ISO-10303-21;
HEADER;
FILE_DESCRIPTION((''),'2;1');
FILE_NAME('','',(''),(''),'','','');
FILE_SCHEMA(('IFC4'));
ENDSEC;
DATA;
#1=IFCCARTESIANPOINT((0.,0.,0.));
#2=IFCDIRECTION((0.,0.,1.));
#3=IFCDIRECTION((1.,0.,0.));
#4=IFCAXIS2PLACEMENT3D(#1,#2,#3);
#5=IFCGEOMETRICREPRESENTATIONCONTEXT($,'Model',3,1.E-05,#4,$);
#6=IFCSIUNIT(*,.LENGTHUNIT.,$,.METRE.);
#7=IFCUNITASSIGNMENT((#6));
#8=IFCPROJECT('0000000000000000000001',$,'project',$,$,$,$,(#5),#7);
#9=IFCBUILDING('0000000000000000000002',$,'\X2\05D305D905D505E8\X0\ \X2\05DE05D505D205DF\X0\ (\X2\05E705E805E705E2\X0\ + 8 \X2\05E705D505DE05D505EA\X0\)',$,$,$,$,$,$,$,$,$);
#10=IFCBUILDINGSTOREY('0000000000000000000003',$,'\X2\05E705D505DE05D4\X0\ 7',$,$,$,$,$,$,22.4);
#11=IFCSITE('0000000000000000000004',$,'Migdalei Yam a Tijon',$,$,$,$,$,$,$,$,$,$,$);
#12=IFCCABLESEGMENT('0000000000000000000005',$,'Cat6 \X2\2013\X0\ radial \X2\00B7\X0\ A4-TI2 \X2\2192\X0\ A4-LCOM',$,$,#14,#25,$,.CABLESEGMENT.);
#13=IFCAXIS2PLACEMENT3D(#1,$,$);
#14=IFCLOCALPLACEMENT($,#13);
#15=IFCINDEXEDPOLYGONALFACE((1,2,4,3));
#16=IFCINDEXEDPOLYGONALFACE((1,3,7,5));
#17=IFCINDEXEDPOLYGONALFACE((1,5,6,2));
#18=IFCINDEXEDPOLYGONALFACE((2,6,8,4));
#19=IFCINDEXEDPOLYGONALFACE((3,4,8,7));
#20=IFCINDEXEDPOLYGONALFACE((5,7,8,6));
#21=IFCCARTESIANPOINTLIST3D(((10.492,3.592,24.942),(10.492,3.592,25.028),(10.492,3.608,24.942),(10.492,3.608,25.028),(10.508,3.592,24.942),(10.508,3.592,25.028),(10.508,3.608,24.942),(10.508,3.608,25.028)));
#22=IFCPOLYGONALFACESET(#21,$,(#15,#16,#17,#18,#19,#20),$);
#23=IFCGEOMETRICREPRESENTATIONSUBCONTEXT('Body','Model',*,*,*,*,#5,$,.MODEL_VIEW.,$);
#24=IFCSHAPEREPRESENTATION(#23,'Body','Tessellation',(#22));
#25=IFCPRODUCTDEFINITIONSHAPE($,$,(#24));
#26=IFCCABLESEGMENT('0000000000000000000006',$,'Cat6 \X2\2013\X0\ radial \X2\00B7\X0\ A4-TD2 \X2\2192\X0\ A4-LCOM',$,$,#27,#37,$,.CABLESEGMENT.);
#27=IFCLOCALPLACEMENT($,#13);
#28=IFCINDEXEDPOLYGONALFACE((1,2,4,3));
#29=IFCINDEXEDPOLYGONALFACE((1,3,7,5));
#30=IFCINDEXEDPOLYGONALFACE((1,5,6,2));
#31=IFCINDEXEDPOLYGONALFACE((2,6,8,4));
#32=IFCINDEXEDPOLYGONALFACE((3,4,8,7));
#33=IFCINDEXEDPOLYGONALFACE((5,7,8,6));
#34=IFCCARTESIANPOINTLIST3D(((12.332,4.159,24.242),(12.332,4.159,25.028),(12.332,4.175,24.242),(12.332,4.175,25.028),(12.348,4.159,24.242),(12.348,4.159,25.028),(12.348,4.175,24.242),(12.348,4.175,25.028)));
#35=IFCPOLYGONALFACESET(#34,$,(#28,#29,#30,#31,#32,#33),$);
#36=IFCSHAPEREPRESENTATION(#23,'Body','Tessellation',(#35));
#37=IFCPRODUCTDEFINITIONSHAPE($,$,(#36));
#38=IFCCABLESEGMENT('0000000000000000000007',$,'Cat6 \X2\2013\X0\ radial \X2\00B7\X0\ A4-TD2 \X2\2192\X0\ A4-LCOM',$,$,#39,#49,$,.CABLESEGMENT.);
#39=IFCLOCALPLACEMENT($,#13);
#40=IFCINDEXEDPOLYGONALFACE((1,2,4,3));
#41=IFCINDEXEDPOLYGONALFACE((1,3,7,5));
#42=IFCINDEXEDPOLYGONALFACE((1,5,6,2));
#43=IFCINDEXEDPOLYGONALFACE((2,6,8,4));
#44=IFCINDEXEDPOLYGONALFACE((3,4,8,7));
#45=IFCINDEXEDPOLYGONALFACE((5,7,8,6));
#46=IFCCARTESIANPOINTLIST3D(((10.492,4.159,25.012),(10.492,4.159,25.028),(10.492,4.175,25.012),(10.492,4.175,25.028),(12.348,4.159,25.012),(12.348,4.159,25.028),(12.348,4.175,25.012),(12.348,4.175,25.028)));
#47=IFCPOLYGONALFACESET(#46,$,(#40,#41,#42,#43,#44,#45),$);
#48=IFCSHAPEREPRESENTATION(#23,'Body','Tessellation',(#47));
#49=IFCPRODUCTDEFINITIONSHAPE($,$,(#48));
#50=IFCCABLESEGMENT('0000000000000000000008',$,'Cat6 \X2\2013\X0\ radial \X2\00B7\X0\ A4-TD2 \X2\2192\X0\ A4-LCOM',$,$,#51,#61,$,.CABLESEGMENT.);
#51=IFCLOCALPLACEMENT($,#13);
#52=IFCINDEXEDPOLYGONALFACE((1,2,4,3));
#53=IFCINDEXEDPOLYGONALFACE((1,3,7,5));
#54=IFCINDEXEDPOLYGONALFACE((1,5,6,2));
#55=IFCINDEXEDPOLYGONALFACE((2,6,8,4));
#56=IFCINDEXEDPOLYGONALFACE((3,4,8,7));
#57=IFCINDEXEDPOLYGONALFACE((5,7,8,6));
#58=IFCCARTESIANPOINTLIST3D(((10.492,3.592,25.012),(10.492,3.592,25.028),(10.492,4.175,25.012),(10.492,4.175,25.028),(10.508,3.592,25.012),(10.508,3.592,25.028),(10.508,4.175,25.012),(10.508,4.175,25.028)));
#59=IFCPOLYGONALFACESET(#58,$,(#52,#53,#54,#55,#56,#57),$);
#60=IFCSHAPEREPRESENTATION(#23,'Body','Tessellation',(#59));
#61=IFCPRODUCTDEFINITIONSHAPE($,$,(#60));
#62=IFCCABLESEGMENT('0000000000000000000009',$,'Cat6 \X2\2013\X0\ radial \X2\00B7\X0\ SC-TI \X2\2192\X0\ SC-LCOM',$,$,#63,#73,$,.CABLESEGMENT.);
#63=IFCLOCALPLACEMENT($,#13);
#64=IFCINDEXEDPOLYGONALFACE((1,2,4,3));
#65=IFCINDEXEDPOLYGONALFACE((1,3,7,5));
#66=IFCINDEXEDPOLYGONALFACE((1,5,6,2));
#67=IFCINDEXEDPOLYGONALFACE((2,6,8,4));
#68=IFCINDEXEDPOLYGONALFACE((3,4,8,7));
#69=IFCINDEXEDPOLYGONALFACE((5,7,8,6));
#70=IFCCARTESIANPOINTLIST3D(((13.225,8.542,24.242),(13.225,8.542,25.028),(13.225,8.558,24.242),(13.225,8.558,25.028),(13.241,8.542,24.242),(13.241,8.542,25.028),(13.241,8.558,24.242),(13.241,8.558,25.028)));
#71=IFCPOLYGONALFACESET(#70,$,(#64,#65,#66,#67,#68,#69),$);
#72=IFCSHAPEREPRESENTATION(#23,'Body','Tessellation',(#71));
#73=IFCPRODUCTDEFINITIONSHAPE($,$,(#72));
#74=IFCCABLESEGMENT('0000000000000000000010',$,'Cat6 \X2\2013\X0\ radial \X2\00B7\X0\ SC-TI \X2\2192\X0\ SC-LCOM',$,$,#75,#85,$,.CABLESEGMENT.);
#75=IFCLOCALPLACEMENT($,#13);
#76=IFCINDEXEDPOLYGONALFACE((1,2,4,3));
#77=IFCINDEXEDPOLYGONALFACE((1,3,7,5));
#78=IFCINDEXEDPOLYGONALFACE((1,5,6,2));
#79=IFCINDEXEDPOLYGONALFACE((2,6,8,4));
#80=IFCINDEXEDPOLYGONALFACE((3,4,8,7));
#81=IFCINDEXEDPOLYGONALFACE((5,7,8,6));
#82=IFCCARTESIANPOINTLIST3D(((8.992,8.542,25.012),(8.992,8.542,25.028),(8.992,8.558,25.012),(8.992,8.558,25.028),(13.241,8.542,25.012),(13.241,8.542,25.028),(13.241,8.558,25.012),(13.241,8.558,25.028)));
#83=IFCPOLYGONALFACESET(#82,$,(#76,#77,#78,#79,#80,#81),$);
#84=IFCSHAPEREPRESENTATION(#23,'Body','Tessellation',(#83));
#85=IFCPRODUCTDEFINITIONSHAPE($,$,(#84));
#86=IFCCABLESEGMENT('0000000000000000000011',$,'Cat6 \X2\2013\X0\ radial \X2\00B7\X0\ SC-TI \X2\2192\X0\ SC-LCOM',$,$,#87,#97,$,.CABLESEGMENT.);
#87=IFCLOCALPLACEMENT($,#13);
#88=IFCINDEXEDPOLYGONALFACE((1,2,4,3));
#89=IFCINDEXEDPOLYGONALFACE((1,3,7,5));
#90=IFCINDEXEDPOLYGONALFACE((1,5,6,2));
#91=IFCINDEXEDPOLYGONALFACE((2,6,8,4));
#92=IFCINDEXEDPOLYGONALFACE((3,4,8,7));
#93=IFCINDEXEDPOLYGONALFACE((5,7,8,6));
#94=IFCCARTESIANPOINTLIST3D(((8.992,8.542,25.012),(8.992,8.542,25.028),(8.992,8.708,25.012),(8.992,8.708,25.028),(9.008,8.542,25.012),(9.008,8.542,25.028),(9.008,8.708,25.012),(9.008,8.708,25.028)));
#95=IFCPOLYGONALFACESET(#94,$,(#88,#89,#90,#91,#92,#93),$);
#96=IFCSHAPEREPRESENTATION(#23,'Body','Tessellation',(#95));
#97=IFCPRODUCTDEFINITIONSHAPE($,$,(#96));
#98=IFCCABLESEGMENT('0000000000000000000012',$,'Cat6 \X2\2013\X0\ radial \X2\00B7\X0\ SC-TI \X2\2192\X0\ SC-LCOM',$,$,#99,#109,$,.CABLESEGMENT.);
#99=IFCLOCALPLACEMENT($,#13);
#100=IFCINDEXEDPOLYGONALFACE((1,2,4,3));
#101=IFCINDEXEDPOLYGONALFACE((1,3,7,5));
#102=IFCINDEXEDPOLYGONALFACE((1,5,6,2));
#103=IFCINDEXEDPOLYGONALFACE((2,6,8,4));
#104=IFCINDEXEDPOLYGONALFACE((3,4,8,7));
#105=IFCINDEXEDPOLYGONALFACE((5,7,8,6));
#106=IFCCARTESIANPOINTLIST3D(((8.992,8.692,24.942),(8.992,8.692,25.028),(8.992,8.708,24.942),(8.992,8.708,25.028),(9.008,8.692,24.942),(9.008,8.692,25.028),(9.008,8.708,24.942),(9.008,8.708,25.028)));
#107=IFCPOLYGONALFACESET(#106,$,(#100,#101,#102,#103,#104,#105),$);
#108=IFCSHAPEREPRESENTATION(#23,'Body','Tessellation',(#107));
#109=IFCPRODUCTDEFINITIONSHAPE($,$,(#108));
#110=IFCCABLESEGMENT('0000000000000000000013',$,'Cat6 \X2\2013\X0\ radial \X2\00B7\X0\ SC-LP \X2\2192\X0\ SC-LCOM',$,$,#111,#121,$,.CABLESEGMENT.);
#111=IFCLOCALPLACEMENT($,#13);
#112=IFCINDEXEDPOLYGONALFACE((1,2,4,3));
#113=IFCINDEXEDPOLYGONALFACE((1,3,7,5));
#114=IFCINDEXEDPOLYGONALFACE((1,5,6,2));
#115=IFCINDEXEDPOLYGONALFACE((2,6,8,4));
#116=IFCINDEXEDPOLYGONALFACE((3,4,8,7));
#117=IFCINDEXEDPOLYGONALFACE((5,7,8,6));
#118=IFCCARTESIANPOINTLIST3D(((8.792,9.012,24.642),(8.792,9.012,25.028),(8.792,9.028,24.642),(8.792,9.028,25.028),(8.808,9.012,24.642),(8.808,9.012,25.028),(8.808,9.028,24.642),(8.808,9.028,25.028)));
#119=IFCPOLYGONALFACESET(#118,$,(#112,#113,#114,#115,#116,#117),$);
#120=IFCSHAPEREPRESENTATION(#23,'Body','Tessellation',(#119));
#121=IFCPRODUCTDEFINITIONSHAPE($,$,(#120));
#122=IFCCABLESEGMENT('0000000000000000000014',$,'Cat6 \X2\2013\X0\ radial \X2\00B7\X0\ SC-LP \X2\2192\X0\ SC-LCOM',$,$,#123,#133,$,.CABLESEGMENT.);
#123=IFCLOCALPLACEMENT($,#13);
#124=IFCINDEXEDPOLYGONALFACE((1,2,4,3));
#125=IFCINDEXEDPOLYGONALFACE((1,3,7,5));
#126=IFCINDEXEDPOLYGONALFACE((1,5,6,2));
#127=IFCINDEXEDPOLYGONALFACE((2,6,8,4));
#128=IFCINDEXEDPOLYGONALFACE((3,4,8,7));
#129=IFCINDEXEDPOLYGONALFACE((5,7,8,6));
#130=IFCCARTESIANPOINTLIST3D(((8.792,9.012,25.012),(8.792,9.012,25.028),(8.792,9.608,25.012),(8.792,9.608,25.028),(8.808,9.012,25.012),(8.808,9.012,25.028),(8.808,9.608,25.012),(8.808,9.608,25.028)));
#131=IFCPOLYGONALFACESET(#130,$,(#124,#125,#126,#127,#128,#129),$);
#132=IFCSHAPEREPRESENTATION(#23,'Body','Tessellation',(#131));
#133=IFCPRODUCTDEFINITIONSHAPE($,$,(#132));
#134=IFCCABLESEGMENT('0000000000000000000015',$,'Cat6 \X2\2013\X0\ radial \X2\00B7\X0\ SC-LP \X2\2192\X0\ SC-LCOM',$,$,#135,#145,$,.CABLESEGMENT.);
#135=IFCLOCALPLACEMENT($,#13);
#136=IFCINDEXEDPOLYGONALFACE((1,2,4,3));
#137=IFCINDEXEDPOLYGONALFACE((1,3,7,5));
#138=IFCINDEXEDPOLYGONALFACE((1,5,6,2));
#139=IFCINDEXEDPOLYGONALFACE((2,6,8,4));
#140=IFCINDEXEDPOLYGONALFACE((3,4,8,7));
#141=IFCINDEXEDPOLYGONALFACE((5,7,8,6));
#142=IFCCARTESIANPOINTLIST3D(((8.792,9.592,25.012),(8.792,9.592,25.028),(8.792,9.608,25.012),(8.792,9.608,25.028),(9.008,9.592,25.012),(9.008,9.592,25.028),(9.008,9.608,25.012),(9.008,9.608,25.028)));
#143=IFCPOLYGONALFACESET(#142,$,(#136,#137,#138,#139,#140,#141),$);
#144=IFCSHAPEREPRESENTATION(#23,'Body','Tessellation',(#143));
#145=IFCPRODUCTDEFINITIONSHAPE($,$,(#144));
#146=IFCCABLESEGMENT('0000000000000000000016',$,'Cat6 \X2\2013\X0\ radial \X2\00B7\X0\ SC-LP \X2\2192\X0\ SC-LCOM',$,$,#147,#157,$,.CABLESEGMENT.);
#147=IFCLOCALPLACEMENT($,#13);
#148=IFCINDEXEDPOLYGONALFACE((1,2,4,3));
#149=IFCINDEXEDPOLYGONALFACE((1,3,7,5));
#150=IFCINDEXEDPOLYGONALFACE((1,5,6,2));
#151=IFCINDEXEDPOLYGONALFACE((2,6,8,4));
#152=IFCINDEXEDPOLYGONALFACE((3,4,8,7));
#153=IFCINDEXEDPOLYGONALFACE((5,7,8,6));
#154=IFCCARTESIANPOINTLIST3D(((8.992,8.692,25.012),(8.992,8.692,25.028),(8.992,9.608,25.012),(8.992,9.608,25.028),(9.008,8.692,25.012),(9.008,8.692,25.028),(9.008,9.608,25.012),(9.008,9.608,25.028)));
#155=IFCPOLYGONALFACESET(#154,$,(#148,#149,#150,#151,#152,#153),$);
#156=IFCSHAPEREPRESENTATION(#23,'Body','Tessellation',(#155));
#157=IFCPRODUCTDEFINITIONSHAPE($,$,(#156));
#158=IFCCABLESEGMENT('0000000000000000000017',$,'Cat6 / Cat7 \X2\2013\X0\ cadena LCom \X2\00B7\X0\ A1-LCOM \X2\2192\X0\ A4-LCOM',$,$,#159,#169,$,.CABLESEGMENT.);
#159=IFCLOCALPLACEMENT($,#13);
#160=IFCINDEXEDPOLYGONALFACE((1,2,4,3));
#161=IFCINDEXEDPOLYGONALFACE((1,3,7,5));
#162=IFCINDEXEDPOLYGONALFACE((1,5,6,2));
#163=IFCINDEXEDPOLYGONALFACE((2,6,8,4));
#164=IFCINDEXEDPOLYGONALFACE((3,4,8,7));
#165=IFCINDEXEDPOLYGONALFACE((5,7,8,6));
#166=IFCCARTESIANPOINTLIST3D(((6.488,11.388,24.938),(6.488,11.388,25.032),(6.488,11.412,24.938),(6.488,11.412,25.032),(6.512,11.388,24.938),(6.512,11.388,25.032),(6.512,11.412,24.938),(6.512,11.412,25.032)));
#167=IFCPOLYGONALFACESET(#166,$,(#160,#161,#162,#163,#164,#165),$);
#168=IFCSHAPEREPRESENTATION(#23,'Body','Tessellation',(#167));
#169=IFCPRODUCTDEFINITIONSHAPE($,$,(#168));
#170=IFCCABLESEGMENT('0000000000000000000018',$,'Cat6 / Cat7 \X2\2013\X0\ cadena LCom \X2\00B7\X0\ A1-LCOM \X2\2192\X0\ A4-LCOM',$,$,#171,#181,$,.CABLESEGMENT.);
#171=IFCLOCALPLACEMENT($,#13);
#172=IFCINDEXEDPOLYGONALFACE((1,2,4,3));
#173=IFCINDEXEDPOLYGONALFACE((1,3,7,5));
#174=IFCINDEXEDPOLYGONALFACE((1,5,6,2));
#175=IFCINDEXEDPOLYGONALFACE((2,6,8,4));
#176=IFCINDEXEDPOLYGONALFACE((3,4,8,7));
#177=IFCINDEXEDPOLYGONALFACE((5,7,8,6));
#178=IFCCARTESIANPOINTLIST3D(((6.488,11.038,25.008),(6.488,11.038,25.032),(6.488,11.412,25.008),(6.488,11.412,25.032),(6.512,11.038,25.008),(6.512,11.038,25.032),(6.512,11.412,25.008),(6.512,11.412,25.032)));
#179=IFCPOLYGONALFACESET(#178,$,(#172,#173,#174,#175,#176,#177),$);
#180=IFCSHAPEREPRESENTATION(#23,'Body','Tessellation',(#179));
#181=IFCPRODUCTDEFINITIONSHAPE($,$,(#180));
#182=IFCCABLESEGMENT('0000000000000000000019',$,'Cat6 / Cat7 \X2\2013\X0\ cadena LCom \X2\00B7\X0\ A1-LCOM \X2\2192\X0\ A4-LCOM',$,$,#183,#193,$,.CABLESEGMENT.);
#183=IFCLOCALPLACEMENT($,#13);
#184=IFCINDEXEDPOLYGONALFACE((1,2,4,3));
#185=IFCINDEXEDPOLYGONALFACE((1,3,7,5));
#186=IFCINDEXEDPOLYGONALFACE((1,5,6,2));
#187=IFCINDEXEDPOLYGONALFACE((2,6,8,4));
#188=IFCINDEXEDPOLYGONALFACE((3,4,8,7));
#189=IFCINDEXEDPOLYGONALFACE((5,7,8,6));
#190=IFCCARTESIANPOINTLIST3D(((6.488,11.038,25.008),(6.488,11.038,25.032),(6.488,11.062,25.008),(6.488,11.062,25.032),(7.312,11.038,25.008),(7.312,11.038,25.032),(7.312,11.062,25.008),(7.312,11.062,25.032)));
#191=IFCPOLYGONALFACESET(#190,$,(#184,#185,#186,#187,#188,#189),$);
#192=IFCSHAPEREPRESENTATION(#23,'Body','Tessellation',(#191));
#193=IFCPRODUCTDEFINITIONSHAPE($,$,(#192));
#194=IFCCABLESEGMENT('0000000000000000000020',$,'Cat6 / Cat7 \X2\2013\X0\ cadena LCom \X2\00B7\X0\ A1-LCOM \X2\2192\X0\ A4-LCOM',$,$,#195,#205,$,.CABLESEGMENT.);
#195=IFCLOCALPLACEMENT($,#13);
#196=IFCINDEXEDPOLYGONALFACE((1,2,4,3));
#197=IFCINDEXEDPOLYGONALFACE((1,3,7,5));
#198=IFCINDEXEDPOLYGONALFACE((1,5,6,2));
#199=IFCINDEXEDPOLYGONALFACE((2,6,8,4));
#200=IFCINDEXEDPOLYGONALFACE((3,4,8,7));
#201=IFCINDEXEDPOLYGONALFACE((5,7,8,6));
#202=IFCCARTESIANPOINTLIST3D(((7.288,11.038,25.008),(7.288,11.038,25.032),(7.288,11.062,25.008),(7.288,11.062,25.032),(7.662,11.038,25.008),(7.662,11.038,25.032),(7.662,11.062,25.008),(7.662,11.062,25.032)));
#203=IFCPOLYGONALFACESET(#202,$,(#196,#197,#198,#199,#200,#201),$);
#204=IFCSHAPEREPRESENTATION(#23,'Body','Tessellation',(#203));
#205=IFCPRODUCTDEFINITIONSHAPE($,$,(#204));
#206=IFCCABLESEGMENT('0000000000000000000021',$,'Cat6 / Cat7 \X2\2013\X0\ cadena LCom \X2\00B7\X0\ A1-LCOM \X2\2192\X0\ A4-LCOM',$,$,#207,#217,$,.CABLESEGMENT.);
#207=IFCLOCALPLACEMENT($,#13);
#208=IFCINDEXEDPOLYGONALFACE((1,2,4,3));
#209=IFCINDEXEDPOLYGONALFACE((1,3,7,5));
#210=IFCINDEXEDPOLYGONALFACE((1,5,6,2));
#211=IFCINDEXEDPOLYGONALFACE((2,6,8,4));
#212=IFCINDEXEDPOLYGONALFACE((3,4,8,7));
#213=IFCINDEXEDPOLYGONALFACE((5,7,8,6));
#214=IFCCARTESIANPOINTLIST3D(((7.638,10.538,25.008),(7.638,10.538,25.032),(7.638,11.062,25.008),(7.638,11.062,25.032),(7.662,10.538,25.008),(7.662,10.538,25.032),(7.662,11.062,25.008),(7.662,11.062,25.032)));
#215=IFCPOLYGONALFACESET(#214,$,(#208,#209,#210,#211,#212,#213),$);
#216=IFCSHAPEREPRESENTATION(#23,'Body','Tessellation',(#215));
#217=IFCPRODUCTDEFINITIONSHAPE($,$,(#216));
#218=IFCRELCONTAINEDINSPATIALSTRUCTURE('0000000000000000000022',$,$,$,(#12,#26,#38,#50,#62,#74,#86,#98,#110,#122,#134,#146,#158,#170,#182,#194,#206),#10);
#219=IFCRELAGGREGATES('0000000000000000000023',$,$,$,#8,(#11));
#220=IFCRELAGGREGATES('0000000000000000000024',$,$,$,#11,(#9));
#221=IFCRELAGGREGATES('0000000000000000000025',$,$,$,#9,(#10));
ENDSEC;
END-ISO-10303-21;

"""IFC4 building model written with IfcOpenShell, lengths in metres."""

from ifc_helpers import new_model, si_unit, frame, origin_with_axes, context, subcontext, project, spatial, line, indexed_curve, outline, extrude, element, save


model = new_model("IFC4")

# Units and contexts
model_context = context("Model", 3, precision=1e-05, world=origin_with_axes())
body_context = subcontext(model_context, "Body", "Model", "MODEL_VIEW")
ifc_project = project(units=[si_unit("LENGTHUNIT", "METRE")], contexts=[model_context])

# Site, building, storey
site = spatial("IfcSite", under=ifc_project, Name="Migdalei Yam a Tijon")
building = spatial("IfcBuilding", under=site, Name="דיור מוגן (קרקע + 8 קומות)")
storey = spatial("IfcBuildingStorey", under=building, Name="קומה 7", Elevation=22.4)

# Cable segments
element("IfcCableSegment", 1, inside=storey, Name="Cat6 – radial · A4-TI2 → A4-LCOM", PredefinedType="CABLESEGMENT", context=body_context, shape_type="SweptSolid", body=[
    extrude(outline(indexed_curve([(0.0, 0.0), (0.016, 0.0), (0.016, 0.016), (0.0, 0.016)], segments=[line(1, 2, 3, 4, 1)])), frame((10.492, 3.592, 24.942), z_axis=(0.0, 0.0, 1.0), x_axis=(1.0, 0.0, 0.0)), (0.0, 0.0, 1.0), 0.086),
])
element("IfcCableSegment", 2, inside=storey, Name="Cat6 – radial · A4-TD2 → A4-LCOM", PredefinedType="CABLESEGMENT", context=body_context, shape_type="SweptSolid", body=[
    extrude(outline(indexed_curve([(0.0, 0.0), (0.016, 0.0), (0.016, 0.016), (0.0, 0.016)], segments=[line(1, 2, 3, 4, 1)])), frame((12.332, 4.159, 24.242), z_axis=(0.0, 0.0, 1.0), x_axis=(1.0, 0.0, 0.0)), (0.0, 0.0, 1.0), 0.786),
])
element("IfcCableSegment", 3, inside=storey, Name="Cat6 – radial · A4-TD2 → A4-LCOM", PredefinedType="CABLESEGMENT", context=body_context, shape_type="SweptSolid", body=[
    extrude(outline(indexed_curve([(0.0, 0.0), (1.856, 0.0), (1.856, 0.016), (0.0, 0.016)], segments=[line(1, 2, 3, 4, 1)])), frame((10.492, 4.159, 25.012), z_axis=(0.0, 0.0, 1.0), x_axis=(1.0, 0.0, 0.0)), (0.0, 0.0, 1.0), 0.016),
])
element("IfcCableSegment", 4, inside=storey, Name="Cat6 – radial · A4-TD2 → A4-LCOM", PredefinedType="CABLESEGMENT", context=body_context, shape_type="SweptSolid", body=[
    extrude(outline(indexed_curve([(0.0, 0.0), (0.016, 0.0), (0.016, 0.583), (0.0, 0.583)], segments=[line(1, 2, 3, 4, 1)])), frame((10.492, 3.592, 25.012), z_axis=(0.0, 0.0, 1.0), x_axis=(1.0, 0.0, 0.0)), (0.0, 0.0, 1.0), 0.016),
])
element("IfcCableSegment", 5, inside=storey, Name="Cat6 – radial · SC-TI → SC-LCOM", PredefinedType="CABLESEGMENT", context=body_context, shape_type="SweptSolid", body=[
    extrude(outline(indexed_curve([(0.0, 0.0), (0.016, 0.0), (0.016, 0.016), (0.0, 0.016)], segments=[line(1, 2, 3, 4, 1)])), frame((13.225, 8.542, 24.242), z_axis=(0.0, 0.0, 1.0), x_axis=(1.0, 0.0, 0.0)), (0.0, 0.0, 1.0), 0.786),
])
element("IfcCableSegment", 6, inside=storey, Name="Cat6 – radial · SC-TI → SC-LCOM", PredefinedType="CABLESEGMENT", context=body_context, shape_type="SweptSolid", body=[
    extrude(outline(indexed_curve([(0.0, 0.0), (4.249, 0.0), (4.249, 0.016), (0.0, 0.016)], segments=[line(1, 2, 3, 4, 1)])), frame((8.992, 8.542, 25.012), z_axis=(0.0, 0.0, 1.0), x_axis=(1.0, 0.0, 0.0)), (0.0, 0.0, 1.0), 0.016),
])
element("IfcCableSegment", 7, inside=storey, Name="Cat6 – radial · SC-TI → SC-LCOM", PredefinedType="CABLESEGMENT", context=body_context, shape_type="SweptSolid", body=[
    extrude(outline(indexed_curve([(0.0, 0.0), (0.016, 0.0), (0.016, 0.166), (0.0, 0.166)], segments=[line(1, 2, 3, 4, 1)])), frame((8.992, 8.542, 25.012), z_axis=(0.0, 0.0, 1.0), x_axis=(1.0, 0.0, 0.0)), (0.0, 0.0, 1.0), 0.016),
])
element("IfcCableSegment", 8, inside=storey, Name="Cat6 – radial · SC-TI → SC-LCOM", PredefinedType="CABLESEGMENT", context=body_context, shape_type="SweptSolid", body=[
    extrude(outline(indexed_curve([(0.0, 0.0), (0.016, 0.0), (0.016, 0.016), (0.0, 0.016)], segments=[line(1, 2, 3, 4, 1)])), frame((8.992, 8.692, 24.942), z_axis=(0.0, 0.0, 1.0), x_axis=(1.0, 0.0, 0.0)), (0.0, 0.0, 1.0), 0.086),
])
element("IfcCableSegment", 9, inside=storey, Name="Cat6 – radial · SC-LP → SC-LCOM", PredefinedType="CABLESEGMENT", context=body_context, shape_type="SweptSolid", body=[
    extrude(outline(indexed_curve([(0.0, 0.0), (0.016, 0.0), (0.016, 0.016), (0.0, 0.016)], segments=[line(1, 2, 3, 4, 1)])), frame((8.792, 9.012, 24.642), z_axis=(0.0, 0.0, 1.0), x_axis=(1.0, 0.0, 0.0)), (0.0, 0.0, 1.0), 0.386),
])
element("IfcCableSegment", 10, inside=storey, Name="Cat6 – radial · SC-LP → SC-LCOM", PredefinedType="CABLESEGMENT", context=body_context, shape_type="SweptSolid", body=[
    extrude(outline(indexed_curve([(0.0, 0.0), (0.016, 0.0), (0.016, 0.596), (0.0, 0.596)], segments=[line(1, 2, 3, 4, 1)])), frame((8.792, 9.012, 25.012), z_axis=(0.0, 0.0, 1.0), x_axis=(1.0, 0.0, 0.0)), (0.0, 0.0, 1.0), 0.016),
])
element("IfcCableSegment", 11, inside=storey, Name="Cat6 – radial · SC-LP → SC-LCOM", PredefinedType="CABLESEGMENT", context=body_context, shape_type="SweptSolid", body=[
    extrude(outline(indexed_curve([(0.0, 0.0), (0.216, 0.0), (0.216, 0.016), (0.0, 0.016)], segments=[line(1, 2, 3, 4, 1)])), frame((8.792, 9.592, 25.012), z_axis=(0.0, 0.0, 1.0), x_axis=(1.0, 0.0, 0.0)), (0.0, 0.0, 1.0), 0.016),
])
element("IfcCableSegment", 12, inside=storey, Name="Cat6 – radial · SC-LP → SC-LCOM", PredefinedType="CABLESEGMENT", context=body_context, shape_type="SweptSolid", body=[
    extrude(outline(indexed_curve([(0.0, 0.0), (0.016, 0.0), (0.016, 0.916), (0.0, 0.916)], segments=[line(1, 2, 3, 4, 1)])), frame((8.992, 8.692, 25.012), z_axis=(0.0, 0.0, 1.0), x_axis=(1.0, 0.0, 0.0)), (0.0, 0.0, 1.0), 0.016),
])
element("IfcCableSegment", 13, inside=storey, Name="Cat6 / Cat7 – cadena LCom · A1-LCOM → A4-LCOM", PredefinedType="CABLESEGMENT", context=body_context, shape_type="SweptSolid", body=[
    extrude(outline(indexed_curve([(0.0, 0.0), (0.024, 0.0), (0.024, 0.024), (0.0, 0.024)], segments=[line(1, 2, 3, 4, 1)])), frame((6.488, 11.388, 24.938), z_axis=(0.0, 0.0, 1.0), x_axis=(1.0, 0.0, 0.0)), (0.0, 0.0, 1.0), 0.094),
])
element("IfcCableSegment", 14, inside=storey, Name="Cat6 / Cat7 – cadena LCom · A1-LCOM → A4-LCOM", PredefinedType="CABLESEGMENT", context=body_context, shape_type="SweptSolid", body=[
    extrude(outline(indexed_curve([(0.0, 0.0), (0.024, 0.0), (0.024, 0.374), (0.0, 0.374)], segments=[line(1, 2, 3, 4, 1)])), frame((6.488, 11.038, 25.008), z_axis=(0.0, 0.0, 1.0), x_axis=(1.0, 0.0, 0.0)), (0.0, 0.0, 1.0), 0.024),
])
element("IfcCableSegment", 15, inside=storey, Name="Cat6 / Cat7 – cadena LCom · A1-LCOM → A4-LCOM", PredefinedType="CABLESEGMENT", context=body_context, shape_type="SweptSolid", body=[
    extrude(outline(indexed_curve([(0.0, 0.0), (0.824, 0.0), (0.824, 0.024), (0.0, 0.024)], segments=[line(1, 2, 3, 4, 1)])), frame((6.488, 11.038, 25.008), z_axis=(0.0, 0.0, 1.0), x_axis=(1.0, 0.0, 0.0)), (0.0, 0.0, 1.0), 0.024),
])
element("IfcCableSegment", 16, inside=storey, Name="Cat6 / Cat7 – cadena LCom · A1-LCOM → A4-LCOM", PredefinedType="CABLESEGMENT", context=body_context, shape_type="SweptSolid", body=[
    extrude(outline(indexed_curve([(0.0, 0.0), (0.374, 0.0), (0.374, 0.024), (0.0, 0.024)], segments=[line(1, 2, 3, 4, 1)])), frame((7.288, 11.038, 25.008), z_axis=(0.0, 0.0, 1.0), x_axis=(1.0, 0.0, 0.0)), (0.0, 0.0, 1.0), 0.024),
])
element("IfcCableSegment", 17, inside=storey, Name="Cat6 / Cat7 – cadena LCom · A1-LCOM → A4-LCOM", PredefinedType="CABLESEGMENT", context=body_context, shape_type="SweptSolid", body=[
    extrude(outline(indexed_curve([(0.0, 0.0), (0.024, 0.0), (0.024, 0.524), (0.0, 0.524)], segments=[line(1, 2, 3, 4, 1)])), frame((7.638, 10.538, 25.008), z_axis=(0.0, 0.0, 1.0), x_axis=(1.0, 0.0, 0.0)), (0.0, 0.0, 1.0), 0.024),
])

save(model, "model.ifc")
